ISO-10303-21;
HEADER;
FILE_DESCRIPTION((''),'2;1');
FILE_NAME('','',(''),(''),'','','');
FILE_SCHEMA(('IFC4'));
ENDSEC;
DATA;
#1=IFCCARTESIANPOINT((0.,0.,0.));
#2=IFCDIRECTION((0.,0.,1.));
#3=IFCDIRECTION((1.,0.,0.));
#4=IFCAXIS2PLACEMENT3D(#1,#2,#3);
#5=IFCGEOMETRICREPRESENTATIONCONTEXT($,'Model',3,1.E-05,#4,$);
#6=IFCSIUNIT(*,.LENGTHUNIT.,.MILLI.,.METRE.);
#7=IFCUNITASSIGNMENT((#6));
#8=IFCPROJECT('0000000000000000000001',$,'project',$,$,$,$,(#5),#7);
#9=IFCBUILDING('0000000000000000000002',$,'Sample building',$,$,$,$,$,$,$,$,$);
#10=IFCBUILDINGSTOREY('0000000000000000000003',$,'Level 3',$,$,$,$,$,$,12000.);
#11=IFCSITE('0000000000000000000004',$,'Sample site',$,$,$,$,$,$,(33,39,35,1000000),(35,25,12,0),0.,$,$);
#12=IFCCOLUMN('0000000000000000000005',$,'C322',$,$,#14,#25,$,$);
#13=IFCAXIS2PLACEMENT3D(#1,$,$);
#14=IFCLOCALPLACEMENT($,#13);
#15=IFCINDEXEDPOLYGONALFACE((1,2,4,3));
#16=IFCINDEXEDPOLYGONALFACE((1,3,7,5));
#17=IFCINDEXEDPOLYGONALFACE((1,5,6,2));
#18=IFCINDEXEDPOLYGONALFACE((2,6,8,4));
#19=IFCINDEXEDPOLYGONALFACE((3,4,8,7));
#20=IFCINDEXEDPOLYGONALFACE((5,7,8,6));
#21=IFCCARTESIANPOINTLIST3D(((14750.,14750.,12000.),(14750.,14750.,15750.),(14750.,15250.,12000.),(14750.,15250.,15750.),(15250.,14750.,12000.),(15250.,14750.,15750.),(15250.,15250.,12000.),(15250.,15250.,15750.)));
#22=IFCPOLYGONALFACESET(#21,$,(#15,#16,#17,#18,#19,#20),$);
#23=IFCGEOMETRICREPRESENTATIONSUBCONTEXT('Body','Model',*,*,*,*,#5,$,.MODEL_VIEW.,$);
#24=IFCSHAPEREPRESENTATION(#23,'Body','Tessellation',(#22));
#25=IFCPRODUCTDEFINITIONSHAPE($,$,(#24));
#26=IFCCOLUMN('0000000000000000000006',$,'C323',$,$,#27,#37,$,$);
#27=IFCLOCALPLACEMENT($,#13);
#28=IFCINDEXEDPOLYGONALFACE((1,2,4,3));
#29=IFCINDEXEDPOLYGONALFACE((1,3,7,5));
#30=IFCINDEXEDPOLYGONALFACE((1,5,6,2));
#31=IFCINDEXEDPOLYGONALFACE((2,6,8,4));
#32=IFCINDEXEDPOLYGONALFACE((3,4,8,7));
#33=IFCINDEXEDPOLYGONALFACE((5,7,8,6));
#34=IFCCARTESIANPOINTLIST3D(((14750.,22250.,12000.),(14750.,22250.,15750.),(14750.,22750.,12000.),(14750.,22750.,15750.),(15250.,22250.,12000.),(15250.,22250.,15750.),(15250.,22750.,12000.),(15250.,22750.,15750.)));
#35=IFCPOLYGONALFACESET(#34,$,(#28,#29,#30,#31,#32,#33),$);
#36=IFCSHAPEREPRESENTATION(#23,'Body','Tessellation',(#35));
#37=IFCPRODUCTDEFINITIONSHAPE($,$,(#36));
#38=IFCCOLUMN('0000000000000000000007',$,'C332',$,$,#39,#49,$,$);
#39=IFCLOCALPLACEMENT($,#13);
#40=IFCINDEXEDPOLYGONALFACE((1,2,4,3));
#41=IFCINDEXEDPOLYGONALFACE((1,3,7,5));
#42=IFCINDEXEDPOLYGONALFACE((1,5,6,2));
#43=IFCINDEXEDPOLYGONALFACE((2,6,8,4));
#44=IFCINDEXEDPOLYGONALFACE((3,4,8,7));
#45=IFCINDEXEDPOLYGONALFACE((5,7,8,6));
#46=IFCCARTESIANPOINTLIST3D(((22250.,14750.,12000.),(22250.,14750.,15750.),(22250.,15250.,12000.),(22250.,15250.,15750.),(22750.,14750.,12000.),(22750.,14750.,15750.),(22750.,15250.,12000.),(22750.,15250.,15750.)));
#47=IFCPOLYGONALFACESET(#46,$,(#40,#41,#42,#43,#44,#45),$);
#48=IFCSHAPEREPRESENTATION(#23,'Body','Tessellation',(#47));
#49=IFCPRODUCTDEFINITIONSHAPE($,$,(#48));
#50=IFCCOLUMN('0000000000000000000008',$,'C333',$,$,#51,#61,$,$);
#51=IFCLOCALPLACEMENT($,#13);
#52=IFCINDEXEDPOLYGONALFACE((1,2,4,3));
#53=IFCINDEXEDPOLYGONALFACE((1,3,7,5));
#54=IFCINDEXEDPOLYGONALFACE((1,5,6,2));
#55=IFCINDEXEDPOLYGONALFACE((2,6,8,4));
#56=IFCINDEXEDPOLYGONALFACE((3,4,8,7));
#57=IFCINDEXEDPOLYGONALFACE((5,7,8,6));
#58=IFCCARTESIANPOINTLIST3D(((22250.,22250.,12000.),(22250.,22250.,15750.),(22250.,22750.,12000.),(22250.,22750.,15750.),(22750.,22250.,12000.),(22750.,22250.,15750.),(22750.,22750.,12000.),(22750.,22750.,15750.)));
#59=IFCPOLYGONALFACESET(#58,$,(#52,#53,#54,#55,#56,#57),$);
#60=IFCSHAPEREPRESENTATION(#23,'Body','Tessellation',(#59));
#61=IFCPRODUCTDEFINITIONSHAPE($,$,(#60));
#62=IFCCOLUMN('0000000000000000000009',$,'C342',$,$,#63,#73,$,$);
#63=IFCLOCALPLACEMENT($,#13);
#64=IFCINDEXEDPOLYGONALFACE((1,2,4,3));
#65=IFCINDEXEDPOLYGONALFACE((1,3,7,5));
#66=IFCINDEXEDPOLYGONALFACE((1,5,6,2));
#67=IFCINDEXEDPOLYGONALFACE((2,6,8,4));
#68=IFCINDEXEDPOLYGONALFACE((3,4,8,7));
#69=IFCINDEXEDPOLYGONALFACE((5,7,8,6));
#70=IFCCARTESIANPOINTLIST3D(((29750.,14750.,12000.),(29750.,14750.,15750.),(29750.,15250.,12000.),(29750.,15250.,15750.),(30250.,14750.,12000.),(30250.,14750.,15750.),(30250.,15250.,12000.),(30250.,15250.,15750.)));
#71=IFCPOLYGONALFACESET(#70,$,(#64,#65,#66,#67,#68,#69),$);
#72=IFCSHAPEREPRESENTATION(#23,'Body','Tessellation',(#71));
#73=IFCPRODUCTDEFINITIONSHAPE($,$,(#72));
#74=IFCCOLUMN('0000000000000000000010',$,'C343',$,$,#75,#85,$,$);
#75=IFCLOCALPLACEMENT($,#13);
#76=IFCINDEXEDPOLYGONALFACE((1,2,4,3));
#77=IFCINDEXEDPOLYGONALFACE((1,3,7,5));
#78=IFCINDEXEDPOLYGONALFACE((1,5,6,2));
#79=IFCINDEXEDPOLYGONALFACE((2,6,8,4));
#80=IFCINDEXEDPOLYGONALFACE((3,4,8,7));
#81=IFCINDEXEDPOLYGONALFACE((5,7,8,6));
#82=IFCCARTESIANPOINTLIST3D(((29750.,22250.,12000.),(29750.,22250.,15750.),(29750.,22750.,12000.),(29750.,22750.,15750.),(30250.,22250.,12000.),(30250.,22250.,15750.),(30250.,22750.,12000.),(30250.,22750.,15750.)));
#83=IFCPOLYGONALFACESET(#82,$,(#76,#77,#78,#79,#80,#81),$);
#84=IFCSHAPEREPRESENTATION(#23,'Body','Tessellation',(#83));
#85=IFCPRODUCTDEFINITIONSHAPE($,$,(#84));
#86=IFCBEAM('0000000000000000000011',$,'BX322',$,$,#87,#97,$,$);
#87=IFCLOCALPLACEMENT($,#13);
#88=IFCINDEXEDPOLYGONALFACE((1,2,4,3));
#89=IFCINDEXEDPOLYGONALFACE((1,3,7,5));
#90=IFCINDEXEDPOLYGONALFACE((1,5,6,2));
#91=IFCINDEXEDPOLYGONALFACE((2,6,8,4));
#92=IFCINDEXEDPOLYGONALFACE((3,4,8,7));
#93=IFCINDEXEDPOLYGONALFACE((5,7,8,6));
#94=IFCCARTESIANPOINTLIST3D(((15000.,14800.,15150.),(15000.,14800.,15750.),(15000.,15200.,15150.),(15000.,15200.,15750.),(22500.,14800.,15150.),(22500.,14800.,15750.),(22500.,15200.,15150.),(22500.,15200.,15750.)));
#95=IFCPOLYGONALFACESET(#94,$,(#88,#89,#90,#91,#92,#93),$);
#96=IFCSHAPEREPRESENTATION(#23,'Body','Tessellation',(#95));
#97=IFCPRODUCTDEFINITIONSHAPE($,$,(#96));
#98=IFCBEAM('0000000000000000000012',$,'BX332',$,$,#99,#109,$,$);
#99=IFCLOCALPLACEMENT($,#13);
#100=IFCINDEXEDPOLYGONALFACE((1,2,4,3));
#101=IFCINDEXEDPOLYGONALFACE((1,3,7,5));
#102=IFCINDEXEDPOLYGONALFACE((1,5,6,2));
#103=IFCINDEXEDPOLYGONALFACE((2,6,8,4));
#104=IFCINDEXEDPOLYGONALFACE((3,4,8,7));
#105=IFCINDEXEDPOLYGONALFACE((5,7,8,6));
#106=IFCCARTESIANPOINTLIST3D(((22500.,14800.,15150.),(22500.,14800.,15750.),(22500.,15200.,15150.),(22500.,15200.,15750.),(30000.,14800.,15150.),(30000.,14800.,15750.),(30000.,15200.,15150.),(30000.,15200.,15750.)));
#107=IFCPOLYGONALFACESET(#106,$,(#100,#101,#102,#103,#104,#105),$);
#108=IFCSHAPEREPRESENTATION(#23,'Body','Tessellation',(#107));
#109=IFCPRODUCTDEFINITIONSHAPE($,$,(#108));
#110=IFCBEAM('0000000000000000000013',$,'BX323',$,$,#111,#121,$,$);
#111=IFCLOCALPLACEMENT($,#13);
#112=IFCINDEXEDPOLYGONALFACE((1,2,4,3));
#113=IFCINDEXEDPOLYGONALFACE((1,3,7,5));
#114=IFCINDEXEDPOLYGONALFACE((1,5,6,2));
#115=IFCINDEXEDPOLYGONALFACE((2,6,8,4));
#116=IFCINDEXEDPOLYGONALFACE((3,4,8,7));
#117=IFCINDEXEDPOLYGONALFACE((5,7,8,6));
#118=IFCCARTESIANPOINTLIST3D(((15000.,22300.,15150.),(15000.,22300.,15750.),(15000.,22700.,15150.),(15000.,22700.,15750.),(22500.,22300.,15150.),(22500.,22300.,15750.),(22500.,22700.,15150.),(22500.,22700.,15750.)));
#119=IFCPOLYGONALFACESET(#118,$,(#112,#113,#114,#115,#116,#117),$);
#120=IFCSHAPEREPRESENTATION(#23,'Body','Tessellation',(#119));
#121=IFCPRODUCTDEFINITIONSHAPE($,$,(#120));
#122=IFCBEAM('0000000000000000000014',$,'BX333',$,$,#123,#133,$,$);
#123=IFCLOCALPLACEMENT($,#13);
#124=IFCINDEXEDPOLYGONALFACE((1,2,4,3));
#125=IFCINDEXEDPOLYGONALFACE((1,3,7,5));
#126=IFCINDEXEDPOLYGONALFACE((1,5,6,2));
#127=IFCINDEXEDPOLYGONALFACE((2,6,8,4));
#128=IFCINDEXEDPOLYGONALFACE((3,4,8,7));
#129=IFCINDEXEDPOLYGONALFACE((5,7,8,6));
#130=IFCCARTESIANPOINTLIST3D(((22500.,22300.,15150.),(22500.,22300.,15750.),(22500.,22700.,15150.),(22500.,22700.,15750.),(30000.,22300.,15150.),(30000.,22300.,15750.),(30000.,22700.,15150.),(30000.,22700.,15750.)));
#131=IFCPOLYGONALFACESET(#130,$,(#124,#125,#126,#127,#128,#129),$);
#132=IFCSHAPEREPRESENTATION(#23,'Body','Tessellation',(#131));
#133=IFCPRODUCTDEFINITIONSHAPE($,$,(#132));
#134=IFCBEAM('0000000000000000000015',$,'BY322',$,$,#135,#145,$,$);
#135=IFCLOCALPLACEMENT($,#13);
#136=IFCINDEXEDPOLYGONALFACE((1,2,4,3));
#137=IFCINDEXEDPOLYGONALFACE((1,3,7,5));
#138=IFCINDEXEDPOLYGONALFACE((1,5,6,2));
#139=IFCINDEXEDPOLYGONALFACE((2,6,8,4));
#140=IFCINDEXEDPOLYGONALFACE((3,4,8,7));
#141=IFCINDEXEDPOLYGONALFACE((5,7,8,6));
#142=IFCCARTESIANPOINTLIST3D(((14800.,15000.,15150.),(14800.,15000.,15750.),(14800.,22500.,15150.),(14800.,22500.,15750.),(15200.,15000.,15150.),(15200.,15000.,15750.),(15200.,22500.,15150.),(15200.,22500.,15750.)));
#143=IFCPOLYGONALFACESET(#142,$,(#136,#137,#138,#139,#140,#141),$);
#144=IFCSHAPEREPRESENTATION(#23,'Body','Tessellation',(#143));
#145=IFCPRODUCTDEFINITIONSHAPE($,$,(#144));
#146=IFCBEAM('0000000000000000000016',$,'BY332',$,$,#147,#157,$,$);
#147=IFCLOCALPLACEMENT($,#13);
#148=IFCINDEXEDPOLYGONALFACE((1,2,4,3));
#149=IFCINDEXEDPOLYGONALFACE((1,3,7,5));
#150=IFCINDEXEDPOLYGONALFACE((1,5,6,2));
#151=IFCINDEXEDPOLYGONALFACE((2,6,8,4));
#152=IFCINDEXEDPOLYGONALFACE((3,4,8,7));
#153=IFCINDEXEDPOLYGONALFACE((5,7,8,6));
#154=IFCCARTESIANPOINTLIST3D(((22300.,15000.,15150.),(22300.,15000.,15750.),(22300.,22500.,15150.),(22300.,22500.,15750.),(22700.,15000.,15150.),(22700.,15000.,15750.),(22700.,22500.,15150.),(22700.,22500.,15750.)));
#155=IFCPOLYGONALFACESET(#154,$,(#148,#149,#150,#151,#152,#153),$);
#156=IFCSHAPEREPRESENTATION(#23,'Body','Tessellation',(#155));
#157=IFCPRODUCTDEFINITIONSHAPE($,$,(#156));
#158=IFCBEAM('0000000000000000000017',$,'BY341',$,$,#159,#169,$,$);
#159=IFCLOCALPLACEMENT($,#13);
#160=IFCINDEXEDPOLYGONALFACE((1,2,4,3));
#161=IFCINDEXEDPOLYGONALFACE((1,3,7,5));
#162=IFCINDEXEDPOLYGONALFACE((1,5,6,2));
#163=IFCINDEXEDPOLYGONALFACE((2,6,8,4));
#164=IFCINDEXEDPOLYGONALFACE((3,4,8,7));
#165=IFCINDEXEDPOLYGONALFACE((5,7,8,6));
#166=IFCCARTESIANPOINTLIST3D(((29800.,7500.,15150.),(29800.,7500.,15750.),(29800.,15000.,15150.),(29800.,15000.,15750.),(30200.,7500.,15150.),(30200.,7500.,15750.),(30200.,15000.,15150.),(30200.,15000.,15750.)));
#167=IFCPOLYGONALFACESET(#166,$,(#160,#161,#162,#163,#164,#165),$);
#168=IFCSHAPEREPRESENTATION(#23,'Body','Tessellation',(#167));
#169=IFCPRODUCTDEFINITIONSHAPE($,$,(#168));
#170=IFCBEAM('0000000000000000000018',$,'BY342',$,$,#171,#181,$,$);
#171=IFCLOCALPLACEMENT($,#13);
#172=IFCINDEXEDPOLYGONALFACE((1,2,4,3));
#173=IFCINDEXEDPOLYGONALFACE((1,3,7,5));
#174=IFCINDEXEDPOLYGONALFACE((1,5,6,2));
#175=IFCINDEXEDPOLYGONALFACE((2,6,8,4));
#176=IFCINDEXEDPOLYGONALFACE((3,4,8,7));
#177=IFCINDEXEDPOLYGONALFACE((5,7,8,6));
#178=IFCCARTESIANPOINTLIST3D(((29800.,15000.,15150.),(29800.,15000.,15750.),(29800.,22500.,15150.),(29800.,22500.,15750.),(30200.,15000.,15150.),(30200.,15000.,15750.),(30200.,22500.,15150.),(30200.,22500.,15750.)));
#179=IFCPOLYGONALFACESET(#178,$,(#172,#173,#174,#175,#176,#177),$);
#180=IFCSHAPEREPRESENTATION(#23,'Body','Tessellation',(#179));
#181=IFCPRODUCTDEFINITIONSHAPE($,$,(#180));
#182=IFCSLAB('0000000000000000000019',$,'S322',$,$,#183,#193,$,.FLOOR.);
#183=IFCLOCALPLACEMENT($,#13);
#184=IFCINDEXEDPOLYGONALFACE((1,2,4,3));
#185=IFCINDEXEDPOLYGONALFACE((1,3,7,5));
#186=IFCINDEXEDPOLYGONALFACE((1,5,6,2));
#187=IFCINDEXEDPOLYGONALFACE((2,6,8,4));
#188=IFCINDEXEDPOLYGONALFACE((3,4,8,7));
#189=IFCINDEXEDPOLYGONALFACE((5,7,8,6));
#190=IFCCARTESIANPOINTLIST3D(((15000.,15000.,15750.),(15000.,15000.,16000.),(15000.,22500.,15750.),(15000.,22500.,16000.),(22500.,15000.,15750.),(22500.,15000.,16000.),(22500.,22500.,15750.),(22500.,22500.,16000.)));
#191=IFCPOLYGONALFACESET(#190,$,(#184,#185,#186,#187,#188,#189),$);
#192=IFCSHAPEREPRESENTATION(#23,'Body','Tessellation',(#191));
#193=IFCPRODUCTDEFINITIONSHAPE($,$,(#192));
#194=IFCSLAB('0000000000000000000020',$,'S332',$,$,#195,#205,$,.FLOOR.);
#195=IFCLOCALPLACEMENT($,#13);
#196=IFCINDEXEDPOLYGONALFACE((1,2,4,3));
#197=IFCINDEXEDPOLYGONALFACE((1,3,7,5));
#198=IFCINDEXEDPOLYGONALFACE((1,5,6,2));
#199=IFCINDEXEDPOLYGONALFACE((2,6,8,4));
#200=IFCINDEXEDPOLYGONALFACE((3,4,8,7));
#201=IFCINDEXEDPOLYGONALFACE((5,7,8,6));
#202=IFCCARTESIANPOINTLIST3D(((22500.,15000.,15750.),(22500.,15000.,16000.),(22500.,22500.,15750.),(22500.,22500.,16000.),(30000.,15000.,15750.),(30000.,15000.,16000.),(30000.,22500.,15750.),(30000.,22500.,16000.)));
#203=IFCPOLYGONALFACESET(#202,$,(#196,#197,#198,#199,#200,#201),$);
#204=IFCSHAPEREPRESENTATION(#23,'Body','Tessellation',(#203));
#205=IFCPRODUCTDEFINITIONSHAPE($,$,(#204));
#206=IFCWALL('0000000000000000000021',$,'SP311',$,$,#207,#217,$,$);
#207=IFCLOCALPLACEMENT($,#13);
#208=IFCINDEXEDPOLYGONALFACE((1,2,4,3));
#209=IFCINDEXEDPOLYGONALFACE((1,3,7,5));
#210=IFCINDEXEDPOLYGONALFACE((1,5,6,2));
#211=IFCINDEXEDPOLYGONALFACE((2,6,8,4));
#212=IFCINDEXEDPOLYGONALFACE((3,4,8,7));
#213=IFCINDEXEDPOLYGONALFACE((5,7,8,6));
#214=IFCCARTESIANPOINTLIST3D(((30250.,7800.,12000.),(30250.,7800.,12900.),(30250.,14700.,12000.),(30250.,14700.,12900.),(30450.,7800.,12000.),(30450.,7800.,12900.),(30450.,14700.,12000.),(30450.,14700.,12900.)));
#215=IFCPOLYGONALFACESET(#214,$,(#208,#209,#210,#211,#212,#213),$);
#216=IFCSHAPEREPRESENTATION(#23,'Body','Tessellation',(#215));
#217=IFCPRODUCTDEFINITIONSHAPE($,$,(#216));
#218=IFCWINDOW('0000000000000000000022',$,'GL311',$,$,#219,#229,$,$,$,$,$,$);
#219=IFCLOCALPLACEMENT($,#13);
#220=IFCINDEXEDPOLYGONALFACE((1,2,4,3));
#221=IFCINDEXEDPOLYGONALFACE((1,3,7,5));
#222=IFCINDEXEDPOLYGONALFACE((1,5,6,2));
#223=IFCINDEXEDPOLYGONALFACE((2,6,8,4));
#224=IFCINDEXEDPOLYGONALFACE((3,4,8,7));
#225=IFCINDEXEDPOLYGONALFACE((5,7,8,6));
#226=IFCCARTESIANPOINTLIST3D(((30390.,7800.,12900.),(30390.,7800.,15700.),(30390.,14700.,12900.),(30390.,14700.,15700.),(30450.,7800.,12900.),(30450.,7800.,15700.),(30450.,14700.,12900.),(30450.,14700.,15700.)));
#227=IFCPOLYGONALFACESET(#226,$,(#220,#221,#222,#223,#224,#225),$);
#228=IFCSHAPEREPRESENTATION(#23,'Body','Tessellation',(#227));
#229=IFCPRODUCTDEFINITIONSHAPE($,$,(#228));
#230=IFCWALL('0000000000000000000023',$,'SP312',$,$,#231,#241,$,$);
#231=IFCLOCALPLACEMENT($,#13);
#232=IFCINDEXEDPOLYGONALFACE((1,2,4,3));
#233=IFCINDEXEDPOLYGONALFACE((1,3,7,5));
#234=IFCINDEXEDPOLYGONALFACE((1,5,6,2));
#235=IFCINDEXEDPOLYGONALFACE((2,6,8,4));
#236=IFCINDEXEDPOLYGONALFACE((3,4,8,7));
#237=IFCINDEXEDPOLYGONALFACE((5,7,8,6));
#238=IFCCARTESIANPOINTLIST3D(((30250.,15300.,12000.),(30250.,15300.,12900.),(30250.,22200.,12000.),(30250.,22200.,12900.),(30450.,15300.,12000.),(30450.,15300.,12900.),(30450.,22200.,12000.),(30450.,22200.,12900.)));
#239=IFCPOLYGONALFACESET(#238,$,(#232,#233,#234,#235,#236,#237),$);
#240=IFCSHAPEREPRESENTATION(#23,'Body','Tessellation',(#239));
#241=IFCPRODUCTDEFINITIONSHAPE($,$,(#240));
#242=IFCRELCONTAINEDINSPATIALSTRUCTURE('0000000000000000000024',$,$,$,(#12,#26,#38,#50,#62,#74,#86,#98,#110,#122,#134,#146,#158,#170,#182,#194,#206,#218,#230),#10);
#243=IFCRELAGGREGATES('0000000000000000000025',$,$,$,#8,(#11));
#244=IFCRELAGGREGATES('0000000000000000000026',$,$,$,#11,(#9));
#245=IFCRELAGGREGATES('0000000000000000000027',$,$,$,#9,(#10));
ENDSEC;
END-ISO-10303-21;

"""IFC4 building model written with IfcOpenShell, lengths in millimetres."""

from ifc_helpers import new_model, si_unit, frame, origin_with_axes, place, context, subcontext, project, spatial, indexed_curve, outline, extrude, element, save


model = new_model("IFC4")

# Units and contexts
model_context = context("Model", 3, precision=1e-05, world=origin_with_axes())
body_context = subcontext(model_context, "Body", "Model", "MODEL_VIEW")
ifc_project = project(units=[si_unit("LENGTHUNIT", "METRE", prefix="MILLI")], contexts=[model_context])

# Site, building, storey
site = spatial("IfcSite", under=ifc_project, Name="Sample site", RefLatitude=(33, 39, 35, 1000000), RefLongitude=(35, 25, 12, 0), RefElevation=0.0)
building = spatial("IfcBuilding", under=site, Name="Sample building")
storey = spatial("IfcBuildingStorey", under=building, Name="Level 3", Elevation=12000.0)

# Columns
for number, where, z_axis, x_axis, name in (
    (1, (14750.0, 14750.0, 12000.0), (0.0, 0.0, 1.0), (1.0, 0.0, 0.0), "C322"),
    (2, (14750.0, 22250.0, 12000.0), (0.0, 0.0, 1.0), (1.0, 0.0, 0.0), "C323"),
    (3, (22250.0, 14750.0, 12000.0), (0.0, 0.0, 1.0), (1.0, 0.0, 0.0), "C332"),
    (4, (22250.0, 22250.0, 12000.0), (0.0, 0.0, 1.0), (1.0, 0.0, 0.0), "C333"),
    (5, (29750.0, 14750.0, 12000.0), (0.0, 0.0, 1.0), (1.0, 0.0, 0.0), "C342"),
    (6, (29750.0, 22250.0, 12000.0), (0.0, 0.0, 1.0), (1.0, 0.0, 0.0), "C343"),
):
    element("IfcColumn", number, at=place(None, frame(where, z_axis=z_axis, x_axis=x_axis)), inside=storey, Name=name, context=body_context, shape_type="SweptSolid", body=[
        extrude(outline(indexed_curve([(0.0, 0.0), (0.0, 500.0), (500.0, 500.0), (500.0, 0.0), (0.0, 0.0)], self_intersect=False)), origin_with_axes(), (0.0, 0.0, 1.0), 3750.0),
    ])

# Beams
for number, where, z_axis, x_axis, name in (
    (7, (15000.0, 14800.0, 15150.0), (0.0, 0.0, 1.0), (1.0, 0.0, 0.0), "BX322"),
    (8, (22500.0, 14800.0, 15150.0), (0.0, 0.0, 1.0), (1.0, 0.0, 0.0), "BX332"),
    (9, (15000.0, 22300.0, 15150.0), (0.0, 0.0, 1.0), (1.0, 0.0, 0.0), "BX323"),
    (10, (22500.0, 22300.0, 15150.0), (0.0, 0.0, 1.0), (1.0, 0.0, 0.0), "BX333"),
    (11, (15200.0, 15000.0, 15150.0), (0.0, 0.0, 1.0), (0.0, 1.0, 0.0), "BY322"),
    (12, (22700.0, 15000.0, 15150.0), (0.0, 0.0, 1.0), (0.0, 1.0, 0.0), "BY332"),
    (13, (30200.0, 7500.0, 15150.0), (0.0, 0.0, 1.0), (0.0, 1.0, 0.0), "BY341"),
    (14, (30200.0, 15000.0, 15150.0), (0.0, 0.0, 1.0), (0.0, 1.0, 0.0), "BY342"),
):
    element("IfcBeam", number, at=place(None, frame(where, z_axis=z_axis, x_axis=x_axis)), inside=storey, Name=name, context=body_context, shape_type="SweptSolid", body=[
        extrude(outline(indexed_curve([(0.0, 0.0), (0.0, 400.0), (7500.0, 400.0), (7500.0, 0.0), (0.0, 0.0)], self_intersect=False)), origin_with_axes(), (0.0, 0.0, 1.0), 600.0),
    ])

# Slabs
for number, where, z_axis, x_axis, name in (
    (15, (15000.0, 15000.0, 15750.0), (0.0, 0.0, 1.0), (1.0, 0.0, 0.0), "S322"),
    (16, (22500.0, 15000.0, 15750.0), (0.0, 0.0, 1.0), (1.0, 0.0, 0.0), "S332"),
):
    element("IfcSlab", number, at=place(None, frame(where, z_axis=z_axis, x_axis=x_axis)), inside=storey, Name=name, PredefinedType="FLOOR", context=body_context, shape_type="SweptSolid", body=[
        extrude(outline(indexed_curve([(0.0, 0.0), (0.0, 7500.0), (7500.0, 7500.0), (7500.0, 0.0), (0.0, 0.0)], self_intersect=False)), origin_with_axes(), (0.0, 0.0, 1.0), 250.0),
    ])

# Wall
wall_1_placement = place(None, frame((30450.0, 7800.0, 12000.0), z_axis=(0.0, 0.0, 1.0), x_axis=(0.0, 1.0, 0.0)))
element("IfcWall", 17, at=wall_1_placement, inside=storey, Name="SP311", context=body_context, shape_type="SweptSolid", body=[
    extrude(outline(indexed_curve([(0.0, 0.0), (0.0, 200.0), (6900.0, 200.0), (6900.0, 0.0), (0.0, 0.0)], self_intersect=False)), origin_with_axes(), (0.0, 0.0, 1.0), 900.0),
])

# Window
window_1_placement = place(None, frame((30450.0, 7800.0, 12900.0), z_axis=(0.0, 0.0, 1.0), x_axis=(0.0, 1.0, 0.0)))
element("IfcWindow", 18, at=window_1_placement, inside=storey, Name="GL311", context=body_context, shape_type="SweptSolid", body=[
    extrude(outline(indexed_curve([(0.0, 0.0), (0.0, 60.0), (6900.0, 60.0), (6900.0, 0.0), (0.0, 0.0)], self_intersect=False)), origin_with_axes(), (0.0, 0.0, 1.0), 2800.0),
])

# Wall
wall_2_placement = place(None, frame((30450.0, 15300.0, 12000.0), z_axis=(0.0, 0.0, 1.0), x_axis=(0.0, 1.0, 0.0)))
element("IfcWall", 19, at=wall_2_placement, inside=storey, Name="SP312", context=body_context, shape_type="SweptSolid", body=[
    extrude(outline(indexed_curve([(0.0, 0.0), (0.0, 200.0), (6900.0, 200.0), (6900.0, 0.0), (0.0, 0.0)], self_intersect=False)), origin_with_axes(), (0.0, 0.0, 1.0), 900.0),
])

save(model, "model.ifc")
